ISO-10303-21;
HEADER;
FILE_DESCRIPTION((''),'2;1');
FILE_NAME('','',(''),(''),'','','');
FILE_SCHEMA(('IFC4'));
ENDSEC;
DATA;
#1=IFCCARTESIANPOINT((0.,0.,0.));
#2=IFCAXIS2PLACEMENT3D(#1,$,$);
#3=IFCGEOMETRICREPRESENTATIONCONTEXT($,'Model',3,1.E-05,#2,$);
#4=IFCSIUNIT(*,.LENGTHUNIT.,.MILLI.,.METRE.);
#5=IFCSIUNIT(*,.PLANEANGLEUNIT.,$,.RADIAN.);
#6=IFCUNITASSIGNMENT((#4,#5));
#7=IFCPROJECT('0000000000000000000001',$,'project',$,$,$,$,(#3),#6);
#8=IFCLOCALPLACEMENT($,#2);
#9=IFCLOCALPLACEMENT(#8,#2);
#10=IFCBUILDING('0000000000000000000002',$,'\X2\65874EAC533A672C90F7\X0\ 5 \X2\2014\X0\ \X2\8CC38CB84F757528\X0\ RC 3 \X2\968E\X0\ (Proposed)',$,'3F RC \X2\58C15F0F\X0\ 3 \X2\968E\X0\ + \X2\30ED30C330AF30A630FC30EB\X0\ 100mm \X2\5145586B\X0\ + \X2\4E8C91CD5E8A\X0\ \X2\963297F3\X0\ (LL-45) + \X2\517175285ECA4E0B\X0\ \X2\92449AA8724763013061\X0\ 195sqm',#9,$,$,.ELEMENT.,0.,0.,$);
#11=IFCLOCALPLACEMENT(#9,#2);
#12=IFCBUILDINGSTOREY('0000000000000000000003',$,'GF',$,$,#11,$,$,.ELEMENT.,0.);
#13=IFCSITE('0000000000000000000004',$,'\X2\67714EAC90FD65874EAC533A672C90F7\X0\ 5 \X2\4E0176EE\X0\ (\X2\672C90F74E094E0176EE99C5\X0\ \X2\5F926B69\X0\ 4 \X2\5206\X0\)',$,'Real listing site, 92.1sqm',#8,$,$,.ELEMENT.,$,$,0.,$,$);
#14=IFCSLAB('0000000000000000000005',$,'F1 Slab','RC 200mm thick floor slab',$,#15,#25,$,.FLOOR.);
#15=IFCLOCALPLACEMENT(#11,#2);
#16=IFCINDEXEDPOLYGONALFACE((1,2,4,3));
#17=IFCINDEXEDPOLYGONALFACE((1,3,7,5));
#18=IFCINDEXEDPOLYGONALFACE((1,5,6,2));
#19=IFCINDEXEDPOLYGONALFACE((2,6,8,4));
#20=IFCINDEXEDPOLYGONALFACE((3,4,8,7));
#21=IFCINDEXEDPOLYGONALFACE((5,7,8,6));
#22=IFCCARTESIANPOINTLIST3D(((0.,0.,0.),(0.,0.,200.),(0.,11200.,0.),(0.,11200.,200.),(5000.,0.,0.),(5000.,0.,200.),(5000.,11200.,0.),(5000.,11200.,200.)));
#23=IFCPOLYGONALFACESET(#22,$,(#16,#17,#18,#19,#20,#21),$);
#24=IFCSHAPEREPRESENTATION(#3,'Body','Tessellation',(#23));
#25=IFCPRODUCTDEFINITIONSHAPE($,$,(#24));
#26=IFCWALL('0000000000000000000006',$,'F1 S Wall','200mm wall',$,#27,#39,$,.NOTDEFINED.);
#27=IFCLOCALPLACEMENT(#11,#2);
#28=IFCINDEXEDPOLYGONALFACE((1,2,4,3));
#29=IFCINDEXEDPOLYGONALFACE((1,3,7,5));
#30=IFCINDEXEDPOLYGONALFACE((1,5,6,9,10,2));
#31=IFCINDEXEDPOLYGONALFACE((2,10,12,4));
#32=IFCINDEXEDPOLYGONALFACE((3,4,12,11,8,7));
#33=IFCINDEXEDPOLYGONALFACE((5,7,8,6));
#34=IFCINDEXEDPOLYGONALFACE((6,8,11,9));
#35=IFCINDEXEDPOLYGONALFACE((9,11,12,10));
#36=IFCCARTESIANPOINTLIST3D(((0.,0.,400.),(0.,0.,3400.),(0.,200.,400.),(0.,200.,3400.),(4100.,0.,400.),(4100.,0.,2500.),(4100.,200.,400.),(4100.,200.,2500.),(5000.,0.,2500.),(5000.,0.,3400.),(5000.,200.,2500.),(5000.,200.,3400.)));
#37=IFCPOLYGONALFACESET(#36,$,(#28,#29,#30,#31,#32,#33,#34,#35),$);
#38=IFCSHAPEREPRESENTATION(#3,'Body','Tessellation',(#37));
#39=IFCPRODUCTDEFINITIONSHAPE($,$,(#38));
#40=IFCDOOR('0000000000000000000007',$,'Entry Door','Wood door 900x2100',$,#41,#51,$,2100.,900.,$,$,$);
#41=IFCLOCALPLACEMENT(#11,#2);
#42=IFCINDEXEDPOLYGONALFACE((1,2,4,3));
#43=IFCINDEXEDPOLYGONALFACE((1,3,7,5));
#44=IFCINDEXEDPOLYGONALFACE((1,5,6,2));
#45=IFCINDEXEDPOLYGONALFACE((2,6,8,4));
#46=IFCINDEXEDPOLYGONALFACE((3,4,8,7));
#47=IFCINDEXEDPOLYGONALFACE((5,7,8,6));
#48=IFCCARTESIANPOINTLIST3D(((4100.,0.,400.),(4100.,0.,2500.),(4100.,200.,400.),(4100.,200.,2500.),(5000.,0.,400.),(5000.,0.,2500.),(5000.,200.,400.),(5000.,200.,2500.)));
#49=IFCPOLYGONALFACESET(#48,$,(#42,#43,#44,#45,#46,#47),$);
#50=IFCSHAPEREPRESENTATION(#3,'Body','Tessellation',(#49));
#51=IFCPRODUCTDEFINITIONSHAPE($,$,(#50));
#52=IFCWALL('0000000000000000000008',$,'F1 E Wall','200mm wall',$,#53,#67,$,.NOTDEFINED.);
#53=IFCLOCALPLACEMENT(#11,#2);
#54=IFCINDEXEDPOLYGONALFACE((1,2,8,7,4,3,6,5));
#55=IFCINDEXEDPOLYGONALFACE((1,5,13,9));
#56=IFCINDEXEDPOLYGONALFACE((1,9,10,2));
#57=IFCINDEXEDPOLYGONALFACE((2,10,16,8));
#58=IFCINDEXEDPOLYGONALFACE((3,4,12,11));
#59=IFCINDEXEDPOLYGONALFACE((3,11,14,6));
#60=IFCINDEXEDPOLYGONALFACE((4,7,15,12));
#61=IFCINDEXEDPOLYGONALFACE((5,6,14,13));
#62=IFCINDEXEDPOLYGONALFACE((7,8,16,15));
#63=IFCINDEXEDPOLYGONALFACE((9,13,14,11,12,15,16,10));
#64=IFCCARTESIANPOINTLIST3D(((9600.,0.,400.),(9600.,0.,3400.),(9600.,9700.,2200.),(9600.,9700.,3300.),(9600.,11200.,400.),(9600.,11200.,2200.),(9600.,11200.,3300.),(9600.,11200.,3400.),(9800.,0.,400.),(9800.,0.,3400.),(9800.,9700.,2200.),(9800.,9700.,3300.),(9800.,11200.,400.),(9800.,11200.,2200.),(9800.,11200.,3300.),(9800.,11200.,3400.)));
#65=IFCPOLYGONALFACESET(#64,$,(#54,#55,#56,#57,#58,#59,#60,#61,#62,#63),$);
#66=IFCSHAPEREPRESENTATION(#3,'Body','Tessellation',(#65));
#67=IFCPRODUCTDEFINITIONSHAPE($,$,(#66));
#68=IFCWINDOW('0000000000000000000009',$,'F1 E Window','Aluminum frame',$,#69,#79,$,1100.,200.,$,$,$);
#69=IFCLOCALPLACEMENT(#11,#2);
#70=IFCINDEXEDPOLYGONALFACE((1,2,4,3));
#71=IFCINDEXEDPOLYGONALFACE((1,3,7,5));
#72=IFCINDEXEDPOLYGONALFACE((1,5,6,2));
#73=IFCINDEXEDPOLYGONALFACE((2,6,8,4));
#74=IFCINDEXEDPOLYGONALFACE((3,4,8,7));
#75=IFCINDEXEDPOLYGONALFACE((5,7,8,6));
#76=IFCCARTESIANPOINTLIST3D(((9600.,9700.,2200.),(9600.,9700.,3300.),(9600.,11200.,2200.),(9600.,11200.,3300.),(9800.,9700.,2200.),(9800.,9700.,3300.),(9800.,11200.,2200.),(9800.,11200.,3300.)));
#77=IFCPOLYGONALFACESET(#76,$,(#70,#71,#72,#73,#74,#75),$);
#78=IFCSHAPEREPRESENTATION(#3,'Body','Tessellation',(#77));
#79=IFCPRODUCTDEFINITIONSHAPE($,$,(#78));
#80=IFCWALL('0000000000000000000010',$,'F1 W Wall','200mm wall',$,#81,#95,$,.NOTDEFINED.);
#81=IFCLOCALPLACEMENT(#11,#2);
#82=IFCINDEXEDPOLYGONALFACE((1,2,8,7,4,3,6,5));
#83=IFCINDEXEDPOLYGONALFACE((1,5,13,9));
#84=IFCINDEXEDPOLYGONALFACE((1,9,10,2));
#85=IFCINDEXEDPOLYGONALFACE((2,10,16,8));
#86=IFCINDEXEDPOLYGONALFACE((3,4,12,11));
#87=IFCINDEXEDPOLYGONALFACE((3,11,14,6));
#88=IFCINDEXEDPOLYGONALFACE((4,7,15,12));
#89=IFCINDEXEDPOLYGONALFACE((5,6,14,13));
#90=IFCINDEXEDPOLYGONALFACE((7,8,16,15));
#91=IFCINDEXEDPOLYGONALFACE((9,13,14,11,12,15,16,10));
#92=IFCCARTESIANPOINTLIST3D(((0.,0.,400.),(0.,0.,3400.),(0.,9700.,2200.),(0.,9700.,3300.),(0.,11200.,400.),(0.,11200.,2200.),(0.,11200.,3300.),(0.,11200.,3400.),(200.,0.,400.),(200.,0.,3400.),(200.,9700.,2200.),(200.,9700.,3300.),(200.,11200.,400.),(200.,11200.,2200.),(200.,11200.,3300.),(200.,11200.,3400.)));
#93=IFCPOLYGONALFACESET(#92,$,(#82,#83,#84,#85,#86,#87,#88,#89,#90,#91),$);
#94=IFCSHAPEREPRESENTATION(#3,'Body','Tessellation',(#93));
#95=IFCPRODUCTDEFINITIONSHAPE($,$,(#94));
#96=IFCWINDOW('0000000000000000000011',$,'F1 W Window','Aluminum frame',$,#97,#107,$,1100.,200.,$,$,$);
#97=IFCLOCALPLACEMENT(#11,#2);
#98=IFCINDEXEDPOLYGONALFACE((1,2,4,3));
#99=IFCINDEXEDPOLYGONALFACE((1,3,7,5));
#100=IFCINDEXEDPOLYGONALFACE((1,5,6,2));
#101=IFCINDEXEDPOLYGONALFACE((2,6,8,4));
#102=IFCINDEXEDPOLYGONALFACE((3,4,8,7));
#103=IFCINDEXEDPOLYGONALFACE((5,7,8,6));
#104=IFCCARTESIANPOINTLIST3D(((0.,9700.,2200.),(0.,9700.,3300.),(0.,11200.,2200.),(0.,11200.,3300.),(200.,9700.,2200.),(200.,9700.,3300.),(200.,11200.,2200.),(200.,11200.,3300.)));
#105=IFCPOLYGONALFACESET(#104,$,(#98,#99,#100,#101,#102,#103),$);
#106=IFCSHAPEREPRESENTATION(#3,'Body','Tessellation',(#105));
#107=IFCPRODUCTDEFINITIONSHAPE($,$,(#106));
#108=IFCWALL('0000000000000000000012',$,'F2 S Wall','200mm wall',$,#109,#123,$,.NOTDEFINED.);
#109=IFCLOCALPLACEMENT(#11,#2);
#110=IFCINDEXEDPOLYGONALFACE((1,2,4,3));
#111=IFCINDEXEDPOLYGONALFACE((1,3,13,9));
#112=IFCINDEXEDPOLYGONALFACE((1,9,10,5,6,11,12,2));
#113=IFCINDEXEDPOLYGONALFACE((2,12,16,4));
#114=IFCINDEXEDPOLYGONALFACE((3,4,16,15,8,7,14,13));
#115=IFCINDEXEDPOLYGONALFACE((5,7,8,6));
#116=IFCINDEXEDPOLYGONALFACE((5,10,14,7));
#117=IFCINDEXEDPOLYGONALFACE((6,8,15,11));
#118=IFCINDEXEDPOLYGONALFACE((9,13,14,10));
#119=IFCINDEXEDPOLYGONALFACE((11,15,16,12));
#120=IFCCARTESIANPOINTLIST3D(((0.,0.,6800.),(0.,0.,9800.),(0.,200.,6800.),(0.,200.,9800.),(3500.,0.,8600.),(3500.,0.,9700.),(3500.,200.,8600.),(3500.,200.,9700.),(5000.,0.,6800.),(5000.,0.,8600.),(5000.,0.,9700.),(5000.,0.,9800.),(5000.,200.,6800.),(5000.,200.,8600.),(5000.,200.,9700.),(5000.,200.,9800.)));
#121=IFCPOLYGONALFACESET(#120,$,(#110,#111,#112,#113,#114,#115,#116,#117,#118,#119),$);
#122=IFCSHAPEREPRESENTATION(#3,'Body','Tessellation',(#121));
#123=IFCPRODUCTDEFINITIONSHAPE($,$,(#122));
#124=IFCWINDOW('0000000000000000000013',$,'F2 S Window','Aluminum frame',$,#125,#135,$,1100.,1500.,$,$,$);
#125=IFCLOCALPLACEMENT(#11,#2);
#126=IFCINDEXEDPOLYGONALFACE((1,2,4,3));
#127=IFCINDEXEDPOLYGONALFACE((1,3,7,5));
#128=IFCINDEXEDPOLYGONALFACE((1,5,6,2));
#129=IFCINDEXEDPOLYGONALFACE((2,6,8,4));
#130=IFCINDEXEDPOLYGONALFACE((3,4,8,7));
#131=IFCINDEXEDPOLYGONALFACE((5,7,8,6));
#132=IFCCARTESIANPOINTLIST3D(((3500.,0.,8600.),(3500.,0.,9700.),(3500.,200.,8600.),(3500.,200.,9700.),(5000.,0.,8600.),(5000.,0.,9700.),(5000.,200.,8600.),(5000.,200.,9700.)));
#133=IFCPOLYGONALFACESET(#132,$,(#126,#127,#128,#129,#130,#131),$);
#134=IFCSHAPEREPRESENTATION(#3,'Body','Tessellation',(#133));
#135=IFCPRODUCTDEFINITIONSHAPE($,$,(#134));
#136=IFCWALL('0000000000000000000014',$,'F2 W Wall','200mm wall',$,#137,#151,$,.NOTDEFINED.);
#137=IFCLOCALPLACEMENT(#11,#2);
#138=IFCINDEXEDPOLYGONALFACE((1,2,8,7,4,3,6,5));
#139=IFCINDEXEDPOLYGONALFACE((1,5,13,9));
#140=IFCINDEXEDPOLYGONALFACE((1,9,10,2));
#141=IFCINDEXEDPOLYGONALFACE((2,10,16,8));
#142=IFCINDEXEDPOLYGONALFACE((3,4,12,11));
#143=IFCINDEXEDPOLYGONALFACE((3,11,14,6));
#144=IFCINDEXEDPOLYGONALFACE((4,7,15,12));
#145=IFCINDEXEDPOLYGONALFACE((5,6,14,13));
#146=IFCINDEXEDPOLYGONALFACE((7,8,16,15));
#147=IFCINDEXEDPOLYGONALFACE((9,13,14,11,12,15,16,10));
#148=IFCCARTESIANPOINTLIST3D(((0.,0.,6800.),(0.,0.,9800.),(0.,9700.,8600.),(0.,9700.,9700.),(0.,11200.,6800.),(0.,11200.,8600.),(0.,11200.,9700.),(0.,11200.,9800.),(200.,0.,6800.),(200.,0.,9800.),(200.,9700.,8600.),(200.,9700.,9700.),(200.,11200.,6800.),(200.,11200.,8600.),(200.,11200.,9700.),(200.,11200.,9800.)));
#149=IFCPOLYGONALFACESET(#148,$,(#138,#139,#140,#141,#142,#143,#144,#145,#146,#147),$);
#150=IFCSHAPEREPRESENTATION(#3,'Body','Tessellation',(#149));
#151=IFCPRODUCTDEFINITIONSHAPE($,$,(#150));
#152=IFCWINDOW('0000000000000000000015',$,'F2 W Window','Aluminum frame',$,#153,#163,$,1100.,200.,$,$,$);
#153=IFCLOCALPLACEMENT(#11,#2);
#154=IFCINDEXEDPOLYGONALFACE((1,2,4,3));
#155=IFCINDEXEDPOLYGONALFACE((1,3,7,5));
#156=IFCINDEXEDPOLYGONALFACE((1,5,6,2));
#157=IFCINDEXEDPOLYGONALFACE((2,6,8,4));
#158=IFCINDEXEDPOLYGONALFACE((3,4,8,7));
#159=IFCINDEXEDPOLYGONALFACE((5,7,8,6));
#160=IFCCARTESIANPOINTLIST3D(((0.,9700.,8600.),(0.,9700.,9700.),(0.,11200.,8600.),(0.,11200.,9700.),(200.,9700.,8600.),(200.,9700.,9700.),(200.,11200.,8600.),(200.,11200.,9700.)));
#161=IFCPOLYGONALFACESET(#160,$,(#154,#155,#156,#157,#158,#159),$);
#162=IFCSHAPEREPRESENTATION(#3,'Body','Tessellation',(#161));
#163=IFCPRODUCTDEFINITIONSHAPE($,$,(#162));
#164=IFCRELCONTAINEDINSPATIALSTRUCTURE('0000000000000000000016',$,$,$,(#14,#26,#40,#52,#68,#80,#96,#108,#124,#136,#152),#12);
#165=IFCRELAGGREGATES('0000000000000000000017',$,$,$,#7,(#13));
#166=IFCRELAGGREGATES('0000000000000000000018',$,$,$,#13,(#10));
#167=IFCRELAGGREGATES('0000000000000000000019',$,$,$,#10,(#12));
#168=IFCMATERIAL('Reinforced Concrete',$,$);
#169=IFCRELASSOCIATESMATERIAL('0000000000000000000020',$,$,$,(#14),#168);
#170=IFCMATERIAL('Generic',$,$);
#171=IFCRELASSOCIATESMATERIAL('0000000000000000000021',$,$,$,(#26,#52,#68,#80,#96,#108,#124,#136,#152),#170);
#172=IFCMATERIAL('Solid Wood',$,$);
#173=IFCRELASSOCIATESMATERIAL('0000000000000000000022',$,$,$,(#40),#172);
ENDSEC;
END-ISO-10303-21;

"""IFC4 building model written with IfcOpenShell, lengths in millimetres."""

from ifc_helpers import new_model, si_unit, frame, frame_2d, origin, place, context, project, spatial, rectangle, extrude, material, element, fill, save


model = new_model("IFC4")

# Units and contexts
model_context = context("Model", 3, precision=1e-05, world=origin())
ifc_project = project(units=[si_unit("LENGTHUNIT", "METRE", prefix="MILLI"), si_unit("PLANEANGLEUNIT", "RADIAN")], contexts=[model_context])

# Site, building, storey
site_placement = place(None, origin())
site = spatial("IfcSite", under=ifc_project, at=site_placement, Name="東京都文京区本郷 5 丁目 (本郷三丁目駅 徒歩 4 分)", ObjectType="Real listing site, 92.1sqm", CompositionType="ELEMENT", RefElevation=0.0)
building_placement = place(site_placement, origin())
building = spatial("IfcBuilding", under=site, at=building_placement, Name="文京区本郷 5 — 賃貸併用 RC 3 階 (Proposed)", ObjectType="3F RC 壁式 3 階 + ロックウール 100mm 充填 + 二重床 防音 (LL-45) + 共用廊下 鉄骨片持ち 195sqm", CompositionType="ELEMENT", ElevationOfRefHeight=0.0, ElevationOfTerrain=0.0)
storey_placement = place(building_placement, origin())
storey = spatial("IfcBuildingStorey", under=building, at=storey_placement, Name="GF", CompositionType="ELEMENT", Elevation=0.0)

# Slab
ifc_material_1 = material(Name="Reinforced Concrete")
slab_1_placement = place(storey_placement, origin())
element("IfcSlab", 1, at=slab_1_placement, inside=storey, material=ifc_material_1, Name="F1 Slab", Description="RC 200mm thick floor slab", PredefinedType="FLOOR", context=model_context, shape_type="SweptSolid", body=[
    extrude(rectangle(XDim=5000.0, YDim=11200.0, at=frame_2d((2500.0, 5600.0))), origin(), (0.0, 0.0, 1.0), 200.0),
])

# Wall, opening, door
ifc_material_2 = material(Name="Generic")
wall_1_placement = place(storey_placement, frame((0.0, 0.0, 200.0)))
wall_1 = element("IfcWall", 2, at=wall_1_placement, inside=storey, material=ifc_material_2, Name="F1 S Wall", Description="200mm wall", PredefinedType="NOTDEFINED", context=model_context, shape_type="SweptSolid", body=[
    extrude(rectangle(XDim=5000.0, YDim=200.0, at=frame_2d((2500.0, 100.0))), frame((0.0, 0.0, 200.0)), (0.0, 0.0, 1.0), 3000.0),
])
opening_1_placement = place(storey_placement, frame((2050.0, 0.0, 200.0)))
opening_1 = element("IfcOpeningElement", 3, at=opening_1_placement, cuts=wall_1, PredefinedType="NOTDEFINED", context=model_context, shape_type="SweptSolid", body=[
    extrude(rectangle(XDim=900.0, YDim=200.0, at=frame_2d((450.0, 100.0))), frame((2050.0, 0.0, 200.0)), (0.0, 0.0, 1.0), 2100.0),
])
ifc_material_3 = material(Name="Solid Wood")
door_placement = place(storey_placement, frame((2050.0, 0.0, 200.0)))
door = element("IfcDoor", 4, at=door_placement, inside=storey, material=ifc_material_3, Name="Entry Door", Description="Wood door 900x2100", OverallHeight=2100.0, OverallWidth=900.0, context=model_context, shape_type="SweptSolid", body=[
    extrude(rectangle(XDim=900.0, YDim=200.0, at=frame_2d((450.0, 100.0))), frame((2050.0, 0.0, 200.0)), (0.0, 0.0, 1.0), 2100.0),
])
fill(opening_1, door)

# Walls, openings, windows
wall_2_placement = place(storey_placement, frame((4800.0, 0.0, 200.0)))
wall_2 = element("IfcWall", 5, at=wall_2_placement, inside=storey, material=ifc_material_2, Name="F1 E Wall", Description="200mm wall", PredefinedType="NOTDEFINED", context=model_context, shape_type="SweptSolid", body=[
    extrude(rectangle(XDim=200.0, YDim=11200.0, at=frame_2d((100.0, 5600.0))), frame((4800.0, 0.0, 200.0)), (0.0, 0.0, 1.0), 3000.0),
])
opening_2_placement = place(storey_placement, frame((4800.0, 4850.0, 1100.0)))
opening_2 = element("IfcOpeningElement", 6, at=opening_2_placement, cuts=wall_2, PredefinedType="NOTDEFINED", context=model_context, shape_type="SweptSolid", body=[
    extrude(rectangle(XDim=200.0, YDim=1500.0, at=frame_2d((100.0, 750.0))), frame((4800.0, 4850.0, 1100.0)), (0.0, 0.0, 1.0), 1100.0),
])
window_1_placement = place(storey_placement, frame((4800.0, 4850.0, 1100.0)))
window_1 = element("IfcWindow", 7, at=window_1_placement, inside=storey, material=ifc_material_2, Name="F1 E Window", Description="Aluminum frame", OverallHeight=1100.0, OverallWidth=200.0, context=model_context, shape_type="SweptSolid", body=[
    extrude(rectangle(XDim=200.0, YDim=1500.0, at=frame_2d((100.0, 750.0))), frame((4800.0, 4850.0, 1100.0)), (0.0, 0.0, 1.0), 1100.0),
])
fill(opening_2, window_1)
wall_3_placement = place(storey_placement, frame((0.0, 0.0, 200.0)))
wall_3 = element("IfcWall", 8, at=wall_3_placement, inside=storey, material=ifc_material_2, Name="F1 W Wall", Description="200mm wall", PredefinedType="NOTDEFINED", context=model_context, shape_type="SweptSolid", body=[
    extrude(rectangle(XDim=200.0, YDim=11200.0, at=frame_2d((100.0, 5600.0))), frame((0.0, 0.0, 200.0)), (0.0, 0.0, 1.0), 3000.0),
])
opening_3_placement = place(storey_placement, frame((0.0, 4850.0, 1100.0)))
opening_3 = element("IfcOpeningElement", 9, at=opening_3_placement, cuts=wall_3, PredefinedType="NOTDEFINED", context=model_context, shape_type="SweptSolid", body=[
    extrude(rectangle(XDim=200.0, YDim=1500.0, at=frame_2d((100.0, 750.0))), frame((0.0, 4850.0, 1100.0)), (0.0, 0.0, 1.0), 1100.0),
])
window_2_placement = place(storey_placement, frame((0.0, 4850.0, 1100.0)))
window_2 = element("IfcWindow", 10, at=window_2_placement, inside=storey, material=ifc_material_2, Name="F1 W Window", Description="Aluminum frame", OverallHeight=1100.0, OverallWidth=200.0, context=model_context, shape_type="SweptSolid", body=[
    extrude(rectangle(XDim=200.0, YDim=1500.0, at=frame_2d((100.0, 750.0))), frame((0.0, 4850.0, 1100.0)), (0.0, 0.0, 1.0), 1100.0),
])
fill(opening_3, window_2)
wall_4_placement = place(storey_placement, frame((0.0, 0.0, 3400.0)))
wall_4 = element("IfcWall", 11, at=wall_4_placement, inside=storey, material=ifc_material_2, Name="F2 S Wall", Description="200mm wall", PredefinedType="NOTDEFINED", context=model_context, shape_type="SweptSolid", body=[
    extrude(rectangle(XDim=5000.0, YDim=200.0, at=frame_2d((2500.0, 100.0))), frame((0.0, 0.0, 3400.0)), (0.0, 0.0, 1.0), 3000.0),
])
opening_4_placement = place(storey_placement, frame((1750.0, 0.0, 4300.0)))
opening_4 = element("IfcOpeningElement", 12, at=opening_4_placement, cuts=wall_4, PredefinedType="NOTDEFINED", context=model_context, shape_type="SweptSolid", body=[
    extrude(rectangle(XDim=1500.0, YDim=200.0, at=frame_2d((750.0, 100.0))), frame((1750.0, 0.0, 4300.0)), (0.0, 0.0, 1.0), 1100.0),
])
window_3_placement = place(storey_placement, frame((1750.0, 0.0, 4300.0)))
window_3 = element("IfcWindow", 13, at=window_3_placement, inside=storey, material=ifc_material_2, Name="F2 S Window", Description="Aluminum frame", OverallHeight=1100.0, OverallWidth=1500.0, context=model_context, shape_type="SweptSolid", body=[
    extrude(rectangle(XDim=1500.0, YDim=200.0, at=frame_2d((750.0, 100.0))), frame((1750.0, 0.0, 4300.0)), (0.0, 0.0, 1.0), 1100.0),
])
fill(opening_4, window_3)
wall_5_placement = place(storey_placement, frame((0.0, 0.0, 3400.0)))
wall_5 = element("IfcWall", 14, at=wall_5_placement, inside=storey, material=ifc_material_2, Name="F2 W Wall", Description="200mm wall", PredefinedType="NOTDEFINED", context=model_context, shape_type="SweptSolid", body=[
    extrude(rectangle(XDim=200.0, YDim=11200.0, at=frame_2d((100.0, 5600.0))), frame((0.0, 0.0, 3400.0)), (0.0, 0.0, 1.0), 3000.0),
])
opening_5_placement = place(storey_placement, frame((0.0, 4850.0, 4300.0)))
opening_5 = element("IfcOpeningElement", 15, at=opening_5_placement, cuts=wall_5, PredefinedType="NOTDEFINED", context=model_context, shape_type="SweptSolid", body=[
    extrude(rectangle(XDim=200.0, YDim=1500.0, at=frame_2d((100.0, 750.0))), frame((0.0, 4850.0, 4300.0)), (0.0, 0.0, 1.0), 1100.0),
])
window_4_placement = place(storey_placement, frame((0.0, 4850.0, 4300.0)))
window_4 = element("IfcWindow", 16, at=window_4_placement, inside=storey, material=ifc_material_2, Name="F2 W Window", Description="Aluminum frame", OverallHeight=1100.0, OverallWidth=200.0, context=model_context, shape_type="SweptSolid", body=[
    extrude(rectangle(XDim=200.0, YDim=1500.0, at=frame_2d((100.0, 750.0))), frame((0.0, 4850.0, 4300.0)), (0.0, 0.0, 1.0), 1100.0),
])
fill(opening_5, window_4)

save(model, "model.ifc")
